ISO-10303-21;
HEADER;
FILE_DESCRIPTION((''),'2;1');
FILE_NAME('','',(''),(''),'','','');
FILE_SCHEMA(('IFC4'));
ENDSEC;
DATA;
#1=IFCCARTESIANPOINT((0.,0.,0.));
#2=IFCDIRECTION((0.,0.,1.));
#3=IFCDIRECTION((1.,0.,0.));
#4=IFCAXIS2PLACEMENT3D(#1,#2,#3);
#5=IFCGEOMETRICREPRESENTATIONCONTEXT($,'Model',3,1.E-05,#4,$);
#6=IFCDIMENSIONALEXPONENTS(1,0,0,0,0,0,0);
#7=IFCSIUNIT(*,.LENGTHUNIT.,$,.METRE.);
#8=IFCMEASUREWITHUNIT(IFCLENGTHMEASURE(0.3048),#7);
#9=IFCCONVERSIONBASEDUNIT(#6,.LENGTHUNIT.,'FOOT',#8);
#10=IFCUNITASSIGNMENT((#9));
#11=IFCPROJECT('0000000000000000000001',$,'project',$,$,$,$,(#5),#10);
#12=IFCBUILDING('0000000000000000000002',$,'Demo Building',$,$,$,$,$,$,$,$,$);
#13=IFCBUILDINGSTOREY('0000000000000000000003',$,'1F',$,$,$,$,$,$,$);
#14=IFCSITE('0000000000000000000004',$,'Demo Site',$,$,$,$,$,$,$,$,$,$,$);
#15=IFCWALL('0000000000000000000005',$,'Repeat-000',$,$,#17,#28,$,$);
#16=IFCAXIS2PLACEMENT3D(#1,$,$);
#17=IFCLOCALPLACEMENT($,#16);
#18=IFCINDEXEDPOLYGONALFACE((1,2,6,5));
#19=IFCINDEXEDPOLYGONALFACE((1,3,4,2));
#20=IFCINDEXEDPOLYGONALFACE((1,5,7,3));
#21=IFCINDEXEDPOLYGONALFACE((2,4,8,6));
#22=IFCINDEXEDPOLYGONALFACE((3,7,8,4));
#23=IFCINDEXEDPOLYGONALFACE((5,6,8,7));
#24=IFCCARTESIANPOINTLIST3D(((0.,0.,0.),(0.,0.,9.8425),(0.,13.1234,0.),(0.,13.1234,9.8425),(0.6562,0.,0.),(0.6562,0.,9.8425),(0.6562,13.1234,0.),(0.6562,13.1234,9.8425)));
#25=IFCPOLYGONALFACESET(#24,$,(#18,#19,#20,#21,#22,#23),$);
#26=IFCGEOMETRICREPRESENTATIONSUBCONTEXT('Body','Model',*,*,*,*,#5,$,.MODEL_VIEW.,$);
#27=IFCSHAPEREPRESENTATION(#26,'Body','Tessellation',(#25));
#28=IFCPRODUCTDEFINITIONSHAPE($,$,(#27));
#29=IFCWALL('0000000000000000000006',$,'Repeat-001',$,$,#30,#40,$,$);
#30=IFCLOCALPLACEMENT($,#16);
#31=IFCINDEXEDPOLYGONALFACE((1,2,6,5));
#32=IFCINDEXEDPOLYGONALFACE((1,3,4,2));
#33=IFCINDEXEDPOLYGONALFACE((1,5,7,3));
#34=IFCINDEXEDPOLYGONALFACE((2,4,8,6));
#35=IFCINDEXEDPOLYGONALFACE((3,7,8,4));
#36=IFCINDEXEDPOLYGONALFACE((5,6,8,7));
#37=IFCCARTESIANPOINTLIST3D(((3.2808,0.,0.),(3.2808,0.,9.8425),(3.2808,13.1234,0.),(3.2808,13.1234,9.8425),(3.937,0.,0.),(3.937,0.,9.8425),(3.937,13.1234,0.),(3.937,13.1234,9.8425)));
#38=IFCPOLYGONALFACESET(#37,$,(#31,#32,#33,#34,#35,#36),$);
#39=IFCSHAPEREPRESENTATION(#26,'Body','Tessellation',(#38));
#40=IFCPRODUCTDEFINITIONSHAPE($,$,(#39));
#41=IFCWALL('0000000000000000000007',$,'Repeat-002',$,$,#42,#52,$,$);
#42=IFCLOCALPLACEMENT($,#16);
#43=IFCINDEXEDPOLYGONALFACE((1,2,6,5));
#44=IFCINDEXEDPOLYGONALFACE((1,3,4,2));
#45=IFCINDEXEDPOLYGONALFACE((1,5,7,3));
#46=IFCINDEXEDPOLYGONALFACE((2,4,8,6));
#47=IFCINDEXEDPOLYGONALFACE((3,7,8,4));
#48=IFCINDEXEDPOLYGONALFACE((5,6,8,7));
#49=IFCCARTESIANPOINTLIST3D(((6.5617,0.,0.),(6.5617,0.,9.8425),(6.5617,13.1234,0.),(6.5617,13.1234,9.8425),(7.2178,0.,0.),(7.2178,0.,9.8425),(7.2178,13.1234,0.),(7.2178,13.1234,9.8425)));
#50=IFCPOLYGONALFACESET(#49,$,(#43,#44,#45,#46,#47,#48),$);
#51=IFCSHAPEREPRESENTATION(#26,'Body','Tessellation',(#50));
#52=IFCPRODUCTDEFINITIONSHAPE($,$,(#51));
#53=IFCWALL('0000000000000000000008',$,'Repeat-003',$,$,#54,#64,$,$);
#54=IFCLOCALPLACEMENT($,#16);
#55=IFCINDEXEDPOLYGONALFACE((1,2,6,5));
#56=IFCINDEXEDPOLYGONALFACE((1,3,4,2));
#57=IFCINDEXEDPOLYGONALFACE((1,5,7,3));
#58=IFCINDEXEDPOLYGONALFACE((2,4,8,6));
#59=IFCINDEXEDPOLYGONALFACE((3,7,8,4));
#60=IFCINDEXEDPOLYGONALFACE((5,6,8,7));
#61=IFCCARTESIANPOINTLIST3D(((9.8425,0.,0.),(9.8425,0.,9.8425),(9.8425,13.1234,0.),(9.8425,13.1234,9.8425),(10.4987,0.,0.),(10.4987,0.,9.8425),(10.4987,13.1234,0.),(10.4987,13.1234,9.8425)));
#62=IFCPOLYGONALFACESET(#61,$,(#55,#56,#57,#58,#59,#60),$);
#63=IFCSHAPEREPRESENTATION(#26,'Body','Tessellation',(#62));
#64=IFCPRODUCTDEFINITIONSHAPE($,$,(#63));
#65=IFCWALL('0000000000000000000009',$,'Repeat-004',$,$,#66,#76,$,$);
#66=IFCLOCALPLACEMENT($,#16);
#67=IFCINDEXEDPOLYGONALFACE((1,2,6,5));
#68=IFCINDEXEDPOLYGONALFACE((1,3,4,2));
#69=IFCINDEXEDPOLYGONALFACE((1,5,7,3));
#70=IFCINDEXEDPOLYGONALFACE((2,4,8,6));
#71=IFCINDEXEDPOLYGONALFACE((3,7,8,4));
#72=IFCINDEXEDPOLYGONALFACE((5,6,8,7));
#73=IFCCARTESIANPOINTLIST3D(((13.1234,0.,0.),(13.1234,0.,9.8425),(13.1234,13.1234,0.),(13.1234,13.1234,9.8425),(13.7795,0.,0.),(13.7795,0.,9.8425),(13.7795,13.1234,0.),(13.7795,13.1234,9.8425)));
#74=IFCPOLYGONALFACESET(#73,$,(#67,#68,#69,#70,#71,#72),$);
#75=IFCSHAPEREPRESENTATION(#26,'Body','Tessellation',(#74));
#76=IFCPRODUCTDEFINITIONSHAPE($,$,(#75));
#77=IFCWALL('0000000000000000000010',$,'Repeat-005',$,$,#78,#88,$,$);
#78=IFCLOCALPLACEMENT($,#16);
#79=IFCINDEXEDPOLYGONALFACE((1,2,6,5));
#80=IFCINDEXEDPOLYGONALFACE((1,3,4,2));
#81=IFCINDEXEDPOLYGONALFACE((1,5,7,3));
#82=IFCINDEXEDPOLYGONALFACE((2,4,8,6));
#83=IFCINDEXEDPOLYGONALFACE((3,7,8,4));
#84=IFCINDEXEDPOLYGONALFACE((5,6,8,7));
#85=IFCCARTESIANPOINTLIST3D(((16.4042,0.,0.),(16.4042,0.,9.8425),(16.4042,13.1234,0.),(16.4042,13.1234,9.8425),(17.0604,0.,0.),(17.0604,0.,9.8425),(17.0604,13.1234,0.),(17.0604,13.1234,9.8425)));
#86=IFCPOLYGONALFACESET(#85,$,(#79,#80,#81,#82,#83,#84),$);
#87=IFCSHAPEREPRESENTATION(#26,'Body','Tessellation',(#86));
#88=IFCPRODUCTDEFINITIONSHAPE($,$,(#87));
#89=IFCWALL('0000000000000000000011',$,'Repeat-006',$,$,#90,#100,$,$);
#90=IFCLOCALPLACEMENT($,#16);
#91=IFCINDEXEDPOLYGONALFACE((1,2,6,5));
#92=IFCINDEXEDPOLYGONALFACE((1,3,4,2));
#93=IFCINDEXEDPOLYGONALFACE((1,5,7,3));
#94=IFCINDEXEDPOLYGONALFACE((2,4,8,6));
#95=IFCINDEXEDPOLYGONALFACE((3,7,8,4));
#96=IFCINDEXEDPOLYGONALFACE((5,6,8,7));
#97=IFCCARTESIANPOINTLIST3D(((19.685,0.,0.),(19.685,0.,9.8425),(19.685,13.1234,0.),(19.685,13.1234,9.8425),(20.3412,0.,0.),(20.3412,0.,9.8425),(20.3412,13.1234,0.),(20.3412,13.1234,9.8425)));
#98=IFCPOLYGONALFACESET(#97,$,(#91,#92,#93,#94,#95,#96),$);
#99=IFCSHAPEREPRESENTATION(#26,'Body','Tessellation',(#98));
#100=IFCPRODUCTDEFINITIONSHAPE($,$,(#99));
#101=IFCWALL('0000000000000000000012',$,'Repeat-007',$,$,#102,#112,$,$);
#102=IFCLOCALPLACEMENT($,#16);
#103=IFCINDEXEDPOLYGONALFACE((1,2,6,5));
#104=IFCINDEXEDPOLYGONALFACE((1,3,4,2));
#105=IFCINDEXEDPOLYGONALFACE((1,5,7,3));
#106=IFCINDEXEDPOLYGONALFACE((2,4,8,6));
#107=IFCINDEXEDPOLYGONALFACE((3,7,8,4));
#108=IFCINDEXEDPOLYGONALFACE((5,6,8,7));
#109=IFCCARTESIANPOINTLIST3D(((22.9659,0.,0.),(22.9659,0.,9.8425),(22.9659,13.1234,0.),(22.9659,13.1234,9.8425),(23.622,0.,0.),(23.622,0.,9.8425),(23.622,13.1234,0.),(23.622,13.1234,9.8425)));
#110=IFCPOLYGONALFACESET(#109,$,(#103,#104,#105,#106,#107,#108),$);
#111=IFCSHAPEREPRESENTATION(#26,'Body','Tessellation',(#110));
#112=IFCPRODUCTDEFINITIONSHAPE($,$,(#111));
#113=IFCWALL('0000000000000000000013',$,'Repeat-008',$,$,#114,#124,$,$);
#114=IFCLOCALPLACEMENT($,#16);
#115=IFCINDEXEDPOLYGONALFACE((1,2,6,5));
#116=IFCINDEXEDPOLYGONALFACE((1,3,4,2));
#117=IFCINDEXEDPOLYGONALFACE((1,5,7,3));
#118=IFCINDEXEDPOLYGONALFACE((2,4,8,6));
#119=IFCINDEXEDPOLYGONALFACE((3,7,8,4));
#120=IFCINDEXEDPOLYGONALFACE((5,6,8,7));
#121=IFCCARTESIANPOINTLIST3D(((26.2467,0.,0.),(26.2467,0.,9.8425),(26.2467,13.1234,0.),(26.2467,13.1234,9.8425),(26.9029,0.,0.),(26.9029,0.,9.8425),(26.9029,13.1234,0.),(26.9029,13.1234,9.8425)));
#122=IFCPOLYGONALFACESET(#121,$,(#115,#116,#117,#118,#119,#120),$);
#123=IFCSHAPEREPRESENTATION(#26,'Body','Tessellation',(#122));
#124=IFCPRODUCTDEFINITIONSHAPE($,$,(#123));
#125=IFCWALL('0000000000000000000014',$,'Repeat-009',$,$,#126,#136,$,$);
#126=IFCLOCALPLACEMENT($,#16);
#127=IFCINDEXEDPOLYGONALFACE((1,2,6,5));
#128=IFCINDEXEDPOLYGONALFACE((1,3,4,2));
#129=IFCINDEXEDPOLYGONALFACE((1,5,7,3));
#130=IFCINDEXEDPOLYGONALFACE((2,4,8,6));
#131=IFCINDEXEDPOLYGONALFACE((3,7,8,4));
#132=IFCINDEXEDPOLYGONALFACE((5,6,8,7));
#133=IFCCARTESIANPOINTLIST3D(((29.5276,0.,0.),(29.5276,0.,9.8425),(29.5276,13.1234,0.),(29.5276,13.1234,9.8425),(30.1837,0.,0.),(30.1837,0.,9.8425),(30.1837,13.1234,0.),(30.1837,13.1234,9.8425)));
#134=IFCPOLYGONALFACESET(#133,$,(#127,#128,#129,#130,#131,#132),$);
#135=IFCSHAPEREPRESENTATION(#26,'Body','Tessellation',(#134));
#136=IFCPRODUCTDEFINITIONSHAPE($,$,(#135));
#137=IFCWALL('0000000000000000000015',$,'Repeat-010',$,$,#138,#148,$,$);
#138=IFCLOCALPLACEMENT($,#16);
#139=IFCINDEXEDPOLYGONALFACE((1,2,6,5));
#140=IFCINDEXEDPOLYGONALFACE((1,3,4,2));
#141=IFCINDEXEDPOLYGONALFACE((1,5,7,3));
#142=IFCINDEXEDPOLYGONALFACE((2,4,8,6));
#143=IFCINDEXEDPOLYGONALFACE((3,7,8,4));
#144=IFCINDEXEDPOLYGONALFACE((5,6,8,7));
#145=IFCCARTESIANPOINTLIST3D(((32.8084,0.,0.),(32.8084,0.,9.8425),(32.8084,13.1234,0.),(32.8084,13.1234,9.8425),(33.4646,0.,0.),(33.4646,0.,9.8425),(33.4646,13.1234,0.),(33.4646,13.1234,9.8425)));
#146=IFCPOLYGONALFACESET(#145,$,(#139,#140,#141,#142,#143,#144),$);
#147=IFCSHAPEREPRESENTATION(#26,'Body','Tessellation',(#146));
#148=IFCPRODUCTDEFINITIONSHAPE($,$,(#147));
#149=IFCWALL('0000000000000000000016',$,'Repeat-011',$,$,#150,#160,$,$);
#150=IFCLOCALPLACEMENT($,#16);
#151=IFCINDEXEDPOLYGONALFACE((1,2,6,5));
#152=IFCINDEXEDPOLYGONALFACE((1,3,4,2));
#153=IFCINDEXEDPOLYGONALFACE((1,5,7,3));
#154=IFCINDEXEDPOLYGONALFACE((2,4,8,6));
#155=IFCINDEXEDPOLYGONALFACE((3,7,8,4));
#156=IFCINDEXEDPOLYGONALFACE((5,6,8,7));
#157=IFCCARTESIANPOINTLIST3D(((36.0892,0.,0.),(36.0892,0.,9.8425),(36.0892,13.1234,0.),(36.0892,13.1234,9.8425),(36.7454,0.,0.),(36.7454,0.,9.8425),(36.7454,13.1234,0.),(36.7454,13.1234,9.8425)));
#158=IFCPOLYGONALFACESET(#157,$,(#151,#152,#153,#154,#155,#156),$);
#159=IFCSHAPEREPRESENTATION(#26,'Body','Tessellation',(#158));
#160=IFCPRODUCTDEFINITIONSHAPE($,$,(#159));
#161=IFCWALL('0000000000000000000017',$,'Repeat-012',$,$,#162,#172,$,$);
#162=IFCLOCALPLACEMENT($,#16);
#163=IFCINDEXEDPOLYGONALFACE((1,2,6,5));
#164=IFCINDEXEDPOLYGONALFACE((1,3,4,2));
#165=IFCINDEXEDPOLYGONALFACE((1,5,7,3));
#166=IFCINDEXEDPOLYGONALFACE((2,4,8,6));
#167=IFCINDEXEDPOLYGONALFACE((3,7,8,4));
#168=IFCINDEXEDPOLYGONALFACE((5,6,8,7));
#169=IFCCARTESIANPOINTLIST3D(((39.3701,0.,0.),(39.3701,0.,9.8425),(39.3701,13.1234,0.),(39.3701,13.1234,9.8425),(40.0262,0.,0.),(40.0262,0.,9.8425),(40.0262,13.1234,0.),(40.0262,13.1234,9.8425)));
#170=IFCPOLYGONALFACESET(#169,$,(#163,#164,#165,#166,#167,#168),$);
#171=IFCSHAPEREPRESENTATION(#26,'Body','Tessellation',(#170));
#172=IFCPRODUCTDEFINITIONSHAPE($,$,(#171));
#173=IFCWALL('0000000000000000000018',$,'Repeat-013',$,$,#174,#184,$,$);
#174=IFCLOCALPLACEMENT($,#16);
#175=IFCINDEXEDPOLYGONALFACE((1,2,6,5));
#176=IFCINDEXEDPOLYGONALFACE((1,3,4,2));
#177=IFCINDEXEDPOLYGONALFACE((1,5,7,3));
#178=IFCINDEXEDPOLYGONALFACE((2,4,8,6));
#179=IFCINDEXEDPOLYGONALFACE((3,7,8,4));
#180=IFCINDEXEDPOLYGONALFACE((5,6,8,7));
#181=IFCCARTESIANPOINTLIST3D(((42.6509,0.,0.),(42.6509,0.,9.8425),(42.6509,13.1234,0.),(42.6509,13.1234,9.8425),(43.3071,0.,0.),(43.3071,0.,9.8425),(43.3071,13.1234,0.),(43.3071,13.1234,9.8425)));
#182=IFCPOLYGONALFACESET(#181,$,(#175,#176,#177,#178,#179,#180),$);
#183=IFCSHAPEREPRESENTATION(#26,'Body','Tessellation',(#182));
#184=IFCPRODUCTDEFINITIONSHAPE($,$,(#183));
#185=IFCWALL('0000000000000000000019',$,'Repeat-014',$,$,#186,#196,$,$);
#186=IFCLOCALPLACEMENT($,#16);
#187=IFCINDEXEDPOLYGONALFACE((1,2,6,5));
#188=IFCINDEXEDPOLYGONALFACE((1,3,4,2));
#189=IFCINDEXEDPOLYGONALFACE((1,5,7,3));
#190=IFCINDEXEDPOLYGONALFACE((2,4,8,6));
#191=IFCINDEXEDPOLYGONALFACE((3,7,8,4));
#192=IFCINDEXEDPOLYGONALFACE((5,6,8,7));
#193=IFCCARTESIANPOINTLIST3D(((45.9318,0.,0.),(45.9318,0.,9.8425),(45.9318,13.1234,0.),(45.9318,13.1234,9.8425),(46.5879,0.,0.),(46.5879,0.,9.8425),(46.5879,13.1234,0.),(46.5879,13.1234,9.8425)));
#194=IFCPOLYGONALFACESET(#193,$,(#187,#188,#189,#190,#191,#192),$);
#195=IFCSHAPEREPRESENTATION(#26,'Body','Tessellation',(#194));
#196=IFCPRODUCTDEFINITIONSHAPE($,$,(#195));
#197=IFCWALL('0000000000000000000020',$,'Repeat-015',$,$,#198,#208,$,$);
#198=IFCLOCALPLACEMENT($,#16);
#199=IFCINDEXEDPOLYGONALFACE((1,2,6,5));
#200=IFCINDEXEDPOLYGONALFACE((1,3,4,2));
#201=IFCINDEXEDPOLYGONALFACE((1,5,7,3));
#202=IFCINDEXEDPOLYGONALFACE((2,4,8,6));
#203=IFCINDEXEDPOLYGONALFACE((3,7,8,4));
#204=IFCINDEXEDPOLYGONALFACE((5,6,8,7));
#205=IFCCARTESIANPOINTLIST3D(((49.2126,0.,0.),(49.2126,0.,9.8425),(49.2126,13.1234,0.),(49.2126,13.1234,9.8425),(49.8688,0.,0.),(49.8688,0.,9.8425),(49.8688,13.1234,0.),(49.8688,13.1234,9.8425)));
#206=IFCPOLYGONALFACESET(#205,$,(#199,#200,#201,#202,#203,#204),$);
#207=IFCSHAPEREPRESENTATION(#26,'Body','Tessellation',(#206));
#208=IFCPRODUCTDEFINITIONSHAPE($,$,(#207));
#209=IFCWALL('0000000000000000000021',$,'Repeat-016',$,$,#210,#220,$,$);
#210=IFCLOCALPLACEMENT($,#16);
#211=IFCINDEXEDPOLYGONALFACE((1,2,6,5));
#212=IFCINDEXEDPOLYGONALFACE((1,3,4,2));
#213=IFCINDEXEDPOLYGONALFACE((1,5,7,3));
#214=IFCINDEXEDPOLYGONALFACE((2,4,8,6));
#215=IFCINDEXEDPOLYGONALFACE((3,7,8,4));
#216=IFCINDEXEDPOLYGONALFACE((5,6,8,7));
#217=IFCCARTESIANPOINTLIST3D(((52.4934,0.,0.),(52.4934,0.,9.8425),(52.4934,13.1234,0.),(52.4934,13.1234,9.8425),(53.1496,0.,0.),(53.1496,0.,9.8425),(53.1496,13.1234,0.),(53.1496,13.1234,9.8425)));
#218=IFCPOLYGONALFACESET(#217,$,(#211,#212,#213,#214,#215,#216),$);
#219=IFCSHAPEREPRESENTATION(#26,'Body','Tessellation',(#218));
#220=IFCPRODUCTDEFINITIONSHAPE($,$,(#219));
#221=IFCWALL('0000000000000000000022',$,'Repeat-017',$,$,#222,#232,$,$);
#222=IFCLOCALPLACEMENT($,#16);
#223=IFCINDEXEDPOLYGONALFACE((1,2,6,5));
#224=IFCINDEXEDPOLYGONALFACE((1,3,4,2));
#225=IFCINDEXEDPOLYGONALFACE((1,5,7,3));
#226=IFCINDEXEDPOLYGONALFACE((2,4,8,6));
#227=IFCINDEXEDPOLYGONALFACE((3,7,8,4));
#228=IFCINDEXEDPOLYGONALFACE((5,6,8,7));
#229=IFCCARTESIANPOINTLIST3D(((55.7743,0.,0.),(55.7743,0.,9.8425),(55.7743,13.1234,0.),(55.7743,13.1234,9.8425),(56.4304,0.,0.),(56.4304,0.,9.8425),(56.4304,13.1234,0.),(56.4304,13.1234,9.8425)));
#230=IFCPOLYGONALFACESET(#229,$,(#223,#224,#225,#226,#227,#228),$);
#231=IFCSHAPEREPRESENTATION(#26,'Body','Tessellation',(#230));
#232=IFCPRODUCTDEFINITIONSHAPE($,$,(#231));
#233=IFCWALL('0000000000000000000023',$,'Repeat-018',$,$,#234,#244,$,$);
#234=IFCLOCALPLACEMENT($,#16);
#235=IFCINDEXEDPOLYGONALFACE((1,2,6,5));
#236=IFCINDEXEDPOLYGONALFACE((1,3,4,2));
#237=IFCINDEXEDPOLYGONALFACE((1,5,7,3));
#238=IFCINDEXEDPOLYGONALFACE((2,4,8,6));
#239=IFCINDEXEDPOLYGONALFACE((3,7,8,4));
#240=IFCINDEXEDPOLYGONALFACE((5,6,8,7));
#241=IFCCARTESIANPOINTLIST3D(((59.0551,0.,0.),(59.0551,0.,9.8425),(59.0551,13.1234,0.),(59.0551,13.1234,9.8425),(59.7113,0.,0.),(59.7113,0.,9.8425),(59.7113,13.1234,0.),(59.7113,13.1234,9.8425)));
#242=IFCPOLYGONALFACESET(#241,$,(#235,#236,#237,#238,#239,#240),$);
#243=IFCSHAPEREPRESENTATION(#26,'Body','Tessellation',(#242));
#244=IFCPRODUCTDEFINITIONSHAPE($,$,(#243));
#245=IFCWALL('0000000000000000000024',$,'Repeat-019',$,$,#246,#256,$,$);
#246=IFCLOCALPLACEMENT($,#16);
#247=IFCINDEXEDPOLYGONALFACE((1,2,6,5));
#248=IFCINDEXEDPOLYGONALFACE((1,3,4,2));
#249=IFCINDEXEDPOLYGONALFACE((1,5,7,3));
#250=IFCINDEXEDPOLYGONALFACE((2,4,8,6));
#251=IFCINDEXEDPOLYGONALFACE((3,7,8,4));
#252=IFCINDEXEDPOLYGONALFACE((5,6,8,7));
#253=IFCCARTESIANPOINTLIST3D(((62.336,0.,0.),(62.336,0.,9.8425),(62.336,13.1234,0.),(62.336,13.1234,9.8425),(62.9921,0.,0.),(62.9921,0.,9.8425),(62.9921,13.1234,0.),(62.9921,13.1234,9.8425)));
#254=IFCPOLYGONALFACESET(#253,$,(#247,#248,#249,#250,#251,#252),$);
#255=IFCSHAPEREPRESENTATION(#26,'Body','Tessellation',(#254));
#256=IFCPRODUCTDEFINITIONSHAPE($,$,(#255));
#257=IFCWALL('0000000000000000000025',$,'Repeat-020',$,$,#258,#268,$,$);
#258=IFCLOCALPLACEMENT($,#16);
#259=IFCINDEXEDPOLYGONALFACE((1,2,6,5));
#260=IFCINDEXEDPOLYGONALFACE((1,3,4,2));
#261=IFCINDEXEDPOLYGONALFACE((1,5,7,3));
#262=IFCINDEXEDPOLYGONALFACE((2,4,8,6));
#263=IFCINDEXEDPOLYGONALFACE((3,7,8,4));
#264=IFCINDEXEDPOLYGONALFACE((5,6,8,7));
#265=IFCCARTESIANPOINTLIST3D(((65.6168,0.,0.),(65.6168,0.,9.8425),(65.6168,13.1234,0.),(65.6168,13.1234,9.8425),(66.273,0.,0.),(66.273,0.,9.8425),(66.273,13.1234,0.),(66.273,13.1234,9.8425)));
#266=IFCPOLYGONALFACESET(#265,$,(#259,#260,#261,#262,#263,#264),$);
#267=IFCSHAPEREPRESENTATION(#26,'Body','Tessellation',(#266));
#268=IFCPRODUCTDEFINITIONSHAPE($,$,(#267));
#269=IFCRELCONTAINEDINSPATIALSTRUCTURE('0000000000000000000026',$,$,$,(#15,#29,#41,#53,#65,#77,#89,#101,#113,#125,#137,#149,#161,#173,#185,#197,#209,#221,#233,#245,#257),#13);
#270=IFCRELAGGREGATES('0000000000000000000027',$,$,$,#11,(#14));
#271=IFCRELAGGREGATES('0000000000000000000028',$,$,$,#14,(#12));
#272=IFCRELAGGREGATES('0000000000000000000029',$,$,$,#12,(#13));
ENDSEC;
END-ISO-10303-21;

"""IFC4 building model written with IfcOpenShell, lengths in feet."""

from ifc_helpers import new_model, entity, si_unit, converted_unit, frame, origin_with_axes, place, context, subcontext, project, spatial, element, save


model = new_model("IFC4")

# Units and contexts
model_context = context("Model", 3, precision=1e-05, world=origin_with_axes())
body_context = subcontext(model_context, "Body", "Model", "MODEL_VIEW")
ifc_project = project(units=[converted_unit("LENGTHUNIT", "FOOT", entity("IfcLengthMeasure", 0.3048), si_unit("LENGTHUNIT", "METRE"), dimensions=[1, 0, 0, 0, 0, 0, 0])], contexts=[model_context])

# Site, building, storey
site = spatial("IfcSite", under=ifc_project, Name="Demo Site")
building = spatial("IfcBuilding", under=site, Name="Demo Building")
storey = spatial("IfcBuildingStorey", under=building, Name="1F")

# Walls
for number, where, z_axis, x_axis, name in (
    (1, (0.0, 0.0, 0.0), (0.0, 0.0, 1.0), (1.0, 0.0, 0.0), "Repeat-000"),
    (2, (3.2808, 0.0, 0.0), (0.0, 0.0, 1.0), (1.0, 0.0, 0.0), "Repeat-001"),
    (3, (6.5617, 0.0, 0.0), (0.0, 0.0, 1.0), (1.0, 0.0, 0.0), "Repeat-002"),
    (4, (9.8425, 0.0, 0.0), (0.0, 0.0, 1.0), (1.0, 0.0, 0.0), "Repeat-003"),
    (5, (13.1234, 0.0, 0.0), (0.0, 0.0, 1.0), (1.0, 0.0, 0.0), "Repeat-004"),
    (6, (16.4042, 0.0, 0.0), (0.0, 0.0, 1.0), (1.0, 0.0, 0.0), "Repeat-005"),
    (7, (19.685, 0.0, 0.0), (0.0, 0.0, 1.0), (1.0, 0.0, 0.0), "Repeat-006"),
    (8, (22.9659, 0.0, 0.0), (0.0, 0.0, 1.0), (1.0, 0.0, 0.0), "Repeat-007"),
    (9, (26.2467, 0.0, 0.0), (0.0, 0.0, 1.0), (1.0, 0.0, 0.0), "Repeat-008"),
    (10, (29.5276, 0.0, 0.0), (0.0, 0.0, 1.0), (1.0, 0.0, 0.0), "Repeat-009"),
    (11, (32.8084, 0.0, 0.0), (0.0, 0.0, 1.0), (1.0, 0.0, 0.0), "Repeat-010"),
    (12, (36.0892, 0.0, 0.0), (0.0, 0.0, 1.0), (1.0, 0.0, 0.0), "Repeat-011"),
    (13, (39.3701, 0.0, 0.0), (0.0, 0.0, 1.0), (1.0, 0.0, 0.0), "Repeat-012"),
    (14, (42.6509, 0.0, 0.0), (0.0, 0.0, 1.0), (1.0, 0.0, 0.0), "Repeat-013"),
    (15, (45.9318, 0.0, 0.0), (0.0, 0.0, 1.0), (1.0, 0.0, 0.0), "Repeat-014"),
    (16, (49.2126, 0.0, 0.0), (0.0, 0.0, 1.0), (1.0, 0.0, 0.0), "Repeat-015"),
    (17, (52.4934, 0.0, 0.0), (0.0, 0.0, 1.0), (1.0, 0.0, 0.0), "Repeat-016"),
    (18, (55.7743, 0.0, 0.0), (0.0, 0.0, 1.0), (1.0, 0.0, 0.0), "Repeat-017"),
    (19, (59.0551, 0.0, 0.0), (0.0, 0.0, 1.0), (1.0, 0.0, 0.0), "Repeat-018"),
    (20, (62.336, 0.0, 0.0), (0.0, 0.0, 1.0), (1.0, 0.0, 0.0), "Repeat-019"),
    (21, (65.6168, 0.0, 0.0), (0.0, 0.0, 1.0), (1.0, 0.0, 0.0), "Repeat-020"),
):
    element("IfcWall", number, at=place(None, frame(where, z_axis=z_axis, x_axis=x_axis)), inside=storey, Name=name, context=body_context, shape_type="CSG", body=[
        entity("IfcBlock", entity("IfcAxis2Placement3D", entity("IfcCartesianPoint", [0.0, 0.0, 0.0]), entity("IfcDirection", [0.0, 0.0, 1.0]), entity("IfcDirection", [1.0, 0.0, 0.0])), 0.6562, 13.1234, 9.8425),
    ])

save(model, "model.ifc")
